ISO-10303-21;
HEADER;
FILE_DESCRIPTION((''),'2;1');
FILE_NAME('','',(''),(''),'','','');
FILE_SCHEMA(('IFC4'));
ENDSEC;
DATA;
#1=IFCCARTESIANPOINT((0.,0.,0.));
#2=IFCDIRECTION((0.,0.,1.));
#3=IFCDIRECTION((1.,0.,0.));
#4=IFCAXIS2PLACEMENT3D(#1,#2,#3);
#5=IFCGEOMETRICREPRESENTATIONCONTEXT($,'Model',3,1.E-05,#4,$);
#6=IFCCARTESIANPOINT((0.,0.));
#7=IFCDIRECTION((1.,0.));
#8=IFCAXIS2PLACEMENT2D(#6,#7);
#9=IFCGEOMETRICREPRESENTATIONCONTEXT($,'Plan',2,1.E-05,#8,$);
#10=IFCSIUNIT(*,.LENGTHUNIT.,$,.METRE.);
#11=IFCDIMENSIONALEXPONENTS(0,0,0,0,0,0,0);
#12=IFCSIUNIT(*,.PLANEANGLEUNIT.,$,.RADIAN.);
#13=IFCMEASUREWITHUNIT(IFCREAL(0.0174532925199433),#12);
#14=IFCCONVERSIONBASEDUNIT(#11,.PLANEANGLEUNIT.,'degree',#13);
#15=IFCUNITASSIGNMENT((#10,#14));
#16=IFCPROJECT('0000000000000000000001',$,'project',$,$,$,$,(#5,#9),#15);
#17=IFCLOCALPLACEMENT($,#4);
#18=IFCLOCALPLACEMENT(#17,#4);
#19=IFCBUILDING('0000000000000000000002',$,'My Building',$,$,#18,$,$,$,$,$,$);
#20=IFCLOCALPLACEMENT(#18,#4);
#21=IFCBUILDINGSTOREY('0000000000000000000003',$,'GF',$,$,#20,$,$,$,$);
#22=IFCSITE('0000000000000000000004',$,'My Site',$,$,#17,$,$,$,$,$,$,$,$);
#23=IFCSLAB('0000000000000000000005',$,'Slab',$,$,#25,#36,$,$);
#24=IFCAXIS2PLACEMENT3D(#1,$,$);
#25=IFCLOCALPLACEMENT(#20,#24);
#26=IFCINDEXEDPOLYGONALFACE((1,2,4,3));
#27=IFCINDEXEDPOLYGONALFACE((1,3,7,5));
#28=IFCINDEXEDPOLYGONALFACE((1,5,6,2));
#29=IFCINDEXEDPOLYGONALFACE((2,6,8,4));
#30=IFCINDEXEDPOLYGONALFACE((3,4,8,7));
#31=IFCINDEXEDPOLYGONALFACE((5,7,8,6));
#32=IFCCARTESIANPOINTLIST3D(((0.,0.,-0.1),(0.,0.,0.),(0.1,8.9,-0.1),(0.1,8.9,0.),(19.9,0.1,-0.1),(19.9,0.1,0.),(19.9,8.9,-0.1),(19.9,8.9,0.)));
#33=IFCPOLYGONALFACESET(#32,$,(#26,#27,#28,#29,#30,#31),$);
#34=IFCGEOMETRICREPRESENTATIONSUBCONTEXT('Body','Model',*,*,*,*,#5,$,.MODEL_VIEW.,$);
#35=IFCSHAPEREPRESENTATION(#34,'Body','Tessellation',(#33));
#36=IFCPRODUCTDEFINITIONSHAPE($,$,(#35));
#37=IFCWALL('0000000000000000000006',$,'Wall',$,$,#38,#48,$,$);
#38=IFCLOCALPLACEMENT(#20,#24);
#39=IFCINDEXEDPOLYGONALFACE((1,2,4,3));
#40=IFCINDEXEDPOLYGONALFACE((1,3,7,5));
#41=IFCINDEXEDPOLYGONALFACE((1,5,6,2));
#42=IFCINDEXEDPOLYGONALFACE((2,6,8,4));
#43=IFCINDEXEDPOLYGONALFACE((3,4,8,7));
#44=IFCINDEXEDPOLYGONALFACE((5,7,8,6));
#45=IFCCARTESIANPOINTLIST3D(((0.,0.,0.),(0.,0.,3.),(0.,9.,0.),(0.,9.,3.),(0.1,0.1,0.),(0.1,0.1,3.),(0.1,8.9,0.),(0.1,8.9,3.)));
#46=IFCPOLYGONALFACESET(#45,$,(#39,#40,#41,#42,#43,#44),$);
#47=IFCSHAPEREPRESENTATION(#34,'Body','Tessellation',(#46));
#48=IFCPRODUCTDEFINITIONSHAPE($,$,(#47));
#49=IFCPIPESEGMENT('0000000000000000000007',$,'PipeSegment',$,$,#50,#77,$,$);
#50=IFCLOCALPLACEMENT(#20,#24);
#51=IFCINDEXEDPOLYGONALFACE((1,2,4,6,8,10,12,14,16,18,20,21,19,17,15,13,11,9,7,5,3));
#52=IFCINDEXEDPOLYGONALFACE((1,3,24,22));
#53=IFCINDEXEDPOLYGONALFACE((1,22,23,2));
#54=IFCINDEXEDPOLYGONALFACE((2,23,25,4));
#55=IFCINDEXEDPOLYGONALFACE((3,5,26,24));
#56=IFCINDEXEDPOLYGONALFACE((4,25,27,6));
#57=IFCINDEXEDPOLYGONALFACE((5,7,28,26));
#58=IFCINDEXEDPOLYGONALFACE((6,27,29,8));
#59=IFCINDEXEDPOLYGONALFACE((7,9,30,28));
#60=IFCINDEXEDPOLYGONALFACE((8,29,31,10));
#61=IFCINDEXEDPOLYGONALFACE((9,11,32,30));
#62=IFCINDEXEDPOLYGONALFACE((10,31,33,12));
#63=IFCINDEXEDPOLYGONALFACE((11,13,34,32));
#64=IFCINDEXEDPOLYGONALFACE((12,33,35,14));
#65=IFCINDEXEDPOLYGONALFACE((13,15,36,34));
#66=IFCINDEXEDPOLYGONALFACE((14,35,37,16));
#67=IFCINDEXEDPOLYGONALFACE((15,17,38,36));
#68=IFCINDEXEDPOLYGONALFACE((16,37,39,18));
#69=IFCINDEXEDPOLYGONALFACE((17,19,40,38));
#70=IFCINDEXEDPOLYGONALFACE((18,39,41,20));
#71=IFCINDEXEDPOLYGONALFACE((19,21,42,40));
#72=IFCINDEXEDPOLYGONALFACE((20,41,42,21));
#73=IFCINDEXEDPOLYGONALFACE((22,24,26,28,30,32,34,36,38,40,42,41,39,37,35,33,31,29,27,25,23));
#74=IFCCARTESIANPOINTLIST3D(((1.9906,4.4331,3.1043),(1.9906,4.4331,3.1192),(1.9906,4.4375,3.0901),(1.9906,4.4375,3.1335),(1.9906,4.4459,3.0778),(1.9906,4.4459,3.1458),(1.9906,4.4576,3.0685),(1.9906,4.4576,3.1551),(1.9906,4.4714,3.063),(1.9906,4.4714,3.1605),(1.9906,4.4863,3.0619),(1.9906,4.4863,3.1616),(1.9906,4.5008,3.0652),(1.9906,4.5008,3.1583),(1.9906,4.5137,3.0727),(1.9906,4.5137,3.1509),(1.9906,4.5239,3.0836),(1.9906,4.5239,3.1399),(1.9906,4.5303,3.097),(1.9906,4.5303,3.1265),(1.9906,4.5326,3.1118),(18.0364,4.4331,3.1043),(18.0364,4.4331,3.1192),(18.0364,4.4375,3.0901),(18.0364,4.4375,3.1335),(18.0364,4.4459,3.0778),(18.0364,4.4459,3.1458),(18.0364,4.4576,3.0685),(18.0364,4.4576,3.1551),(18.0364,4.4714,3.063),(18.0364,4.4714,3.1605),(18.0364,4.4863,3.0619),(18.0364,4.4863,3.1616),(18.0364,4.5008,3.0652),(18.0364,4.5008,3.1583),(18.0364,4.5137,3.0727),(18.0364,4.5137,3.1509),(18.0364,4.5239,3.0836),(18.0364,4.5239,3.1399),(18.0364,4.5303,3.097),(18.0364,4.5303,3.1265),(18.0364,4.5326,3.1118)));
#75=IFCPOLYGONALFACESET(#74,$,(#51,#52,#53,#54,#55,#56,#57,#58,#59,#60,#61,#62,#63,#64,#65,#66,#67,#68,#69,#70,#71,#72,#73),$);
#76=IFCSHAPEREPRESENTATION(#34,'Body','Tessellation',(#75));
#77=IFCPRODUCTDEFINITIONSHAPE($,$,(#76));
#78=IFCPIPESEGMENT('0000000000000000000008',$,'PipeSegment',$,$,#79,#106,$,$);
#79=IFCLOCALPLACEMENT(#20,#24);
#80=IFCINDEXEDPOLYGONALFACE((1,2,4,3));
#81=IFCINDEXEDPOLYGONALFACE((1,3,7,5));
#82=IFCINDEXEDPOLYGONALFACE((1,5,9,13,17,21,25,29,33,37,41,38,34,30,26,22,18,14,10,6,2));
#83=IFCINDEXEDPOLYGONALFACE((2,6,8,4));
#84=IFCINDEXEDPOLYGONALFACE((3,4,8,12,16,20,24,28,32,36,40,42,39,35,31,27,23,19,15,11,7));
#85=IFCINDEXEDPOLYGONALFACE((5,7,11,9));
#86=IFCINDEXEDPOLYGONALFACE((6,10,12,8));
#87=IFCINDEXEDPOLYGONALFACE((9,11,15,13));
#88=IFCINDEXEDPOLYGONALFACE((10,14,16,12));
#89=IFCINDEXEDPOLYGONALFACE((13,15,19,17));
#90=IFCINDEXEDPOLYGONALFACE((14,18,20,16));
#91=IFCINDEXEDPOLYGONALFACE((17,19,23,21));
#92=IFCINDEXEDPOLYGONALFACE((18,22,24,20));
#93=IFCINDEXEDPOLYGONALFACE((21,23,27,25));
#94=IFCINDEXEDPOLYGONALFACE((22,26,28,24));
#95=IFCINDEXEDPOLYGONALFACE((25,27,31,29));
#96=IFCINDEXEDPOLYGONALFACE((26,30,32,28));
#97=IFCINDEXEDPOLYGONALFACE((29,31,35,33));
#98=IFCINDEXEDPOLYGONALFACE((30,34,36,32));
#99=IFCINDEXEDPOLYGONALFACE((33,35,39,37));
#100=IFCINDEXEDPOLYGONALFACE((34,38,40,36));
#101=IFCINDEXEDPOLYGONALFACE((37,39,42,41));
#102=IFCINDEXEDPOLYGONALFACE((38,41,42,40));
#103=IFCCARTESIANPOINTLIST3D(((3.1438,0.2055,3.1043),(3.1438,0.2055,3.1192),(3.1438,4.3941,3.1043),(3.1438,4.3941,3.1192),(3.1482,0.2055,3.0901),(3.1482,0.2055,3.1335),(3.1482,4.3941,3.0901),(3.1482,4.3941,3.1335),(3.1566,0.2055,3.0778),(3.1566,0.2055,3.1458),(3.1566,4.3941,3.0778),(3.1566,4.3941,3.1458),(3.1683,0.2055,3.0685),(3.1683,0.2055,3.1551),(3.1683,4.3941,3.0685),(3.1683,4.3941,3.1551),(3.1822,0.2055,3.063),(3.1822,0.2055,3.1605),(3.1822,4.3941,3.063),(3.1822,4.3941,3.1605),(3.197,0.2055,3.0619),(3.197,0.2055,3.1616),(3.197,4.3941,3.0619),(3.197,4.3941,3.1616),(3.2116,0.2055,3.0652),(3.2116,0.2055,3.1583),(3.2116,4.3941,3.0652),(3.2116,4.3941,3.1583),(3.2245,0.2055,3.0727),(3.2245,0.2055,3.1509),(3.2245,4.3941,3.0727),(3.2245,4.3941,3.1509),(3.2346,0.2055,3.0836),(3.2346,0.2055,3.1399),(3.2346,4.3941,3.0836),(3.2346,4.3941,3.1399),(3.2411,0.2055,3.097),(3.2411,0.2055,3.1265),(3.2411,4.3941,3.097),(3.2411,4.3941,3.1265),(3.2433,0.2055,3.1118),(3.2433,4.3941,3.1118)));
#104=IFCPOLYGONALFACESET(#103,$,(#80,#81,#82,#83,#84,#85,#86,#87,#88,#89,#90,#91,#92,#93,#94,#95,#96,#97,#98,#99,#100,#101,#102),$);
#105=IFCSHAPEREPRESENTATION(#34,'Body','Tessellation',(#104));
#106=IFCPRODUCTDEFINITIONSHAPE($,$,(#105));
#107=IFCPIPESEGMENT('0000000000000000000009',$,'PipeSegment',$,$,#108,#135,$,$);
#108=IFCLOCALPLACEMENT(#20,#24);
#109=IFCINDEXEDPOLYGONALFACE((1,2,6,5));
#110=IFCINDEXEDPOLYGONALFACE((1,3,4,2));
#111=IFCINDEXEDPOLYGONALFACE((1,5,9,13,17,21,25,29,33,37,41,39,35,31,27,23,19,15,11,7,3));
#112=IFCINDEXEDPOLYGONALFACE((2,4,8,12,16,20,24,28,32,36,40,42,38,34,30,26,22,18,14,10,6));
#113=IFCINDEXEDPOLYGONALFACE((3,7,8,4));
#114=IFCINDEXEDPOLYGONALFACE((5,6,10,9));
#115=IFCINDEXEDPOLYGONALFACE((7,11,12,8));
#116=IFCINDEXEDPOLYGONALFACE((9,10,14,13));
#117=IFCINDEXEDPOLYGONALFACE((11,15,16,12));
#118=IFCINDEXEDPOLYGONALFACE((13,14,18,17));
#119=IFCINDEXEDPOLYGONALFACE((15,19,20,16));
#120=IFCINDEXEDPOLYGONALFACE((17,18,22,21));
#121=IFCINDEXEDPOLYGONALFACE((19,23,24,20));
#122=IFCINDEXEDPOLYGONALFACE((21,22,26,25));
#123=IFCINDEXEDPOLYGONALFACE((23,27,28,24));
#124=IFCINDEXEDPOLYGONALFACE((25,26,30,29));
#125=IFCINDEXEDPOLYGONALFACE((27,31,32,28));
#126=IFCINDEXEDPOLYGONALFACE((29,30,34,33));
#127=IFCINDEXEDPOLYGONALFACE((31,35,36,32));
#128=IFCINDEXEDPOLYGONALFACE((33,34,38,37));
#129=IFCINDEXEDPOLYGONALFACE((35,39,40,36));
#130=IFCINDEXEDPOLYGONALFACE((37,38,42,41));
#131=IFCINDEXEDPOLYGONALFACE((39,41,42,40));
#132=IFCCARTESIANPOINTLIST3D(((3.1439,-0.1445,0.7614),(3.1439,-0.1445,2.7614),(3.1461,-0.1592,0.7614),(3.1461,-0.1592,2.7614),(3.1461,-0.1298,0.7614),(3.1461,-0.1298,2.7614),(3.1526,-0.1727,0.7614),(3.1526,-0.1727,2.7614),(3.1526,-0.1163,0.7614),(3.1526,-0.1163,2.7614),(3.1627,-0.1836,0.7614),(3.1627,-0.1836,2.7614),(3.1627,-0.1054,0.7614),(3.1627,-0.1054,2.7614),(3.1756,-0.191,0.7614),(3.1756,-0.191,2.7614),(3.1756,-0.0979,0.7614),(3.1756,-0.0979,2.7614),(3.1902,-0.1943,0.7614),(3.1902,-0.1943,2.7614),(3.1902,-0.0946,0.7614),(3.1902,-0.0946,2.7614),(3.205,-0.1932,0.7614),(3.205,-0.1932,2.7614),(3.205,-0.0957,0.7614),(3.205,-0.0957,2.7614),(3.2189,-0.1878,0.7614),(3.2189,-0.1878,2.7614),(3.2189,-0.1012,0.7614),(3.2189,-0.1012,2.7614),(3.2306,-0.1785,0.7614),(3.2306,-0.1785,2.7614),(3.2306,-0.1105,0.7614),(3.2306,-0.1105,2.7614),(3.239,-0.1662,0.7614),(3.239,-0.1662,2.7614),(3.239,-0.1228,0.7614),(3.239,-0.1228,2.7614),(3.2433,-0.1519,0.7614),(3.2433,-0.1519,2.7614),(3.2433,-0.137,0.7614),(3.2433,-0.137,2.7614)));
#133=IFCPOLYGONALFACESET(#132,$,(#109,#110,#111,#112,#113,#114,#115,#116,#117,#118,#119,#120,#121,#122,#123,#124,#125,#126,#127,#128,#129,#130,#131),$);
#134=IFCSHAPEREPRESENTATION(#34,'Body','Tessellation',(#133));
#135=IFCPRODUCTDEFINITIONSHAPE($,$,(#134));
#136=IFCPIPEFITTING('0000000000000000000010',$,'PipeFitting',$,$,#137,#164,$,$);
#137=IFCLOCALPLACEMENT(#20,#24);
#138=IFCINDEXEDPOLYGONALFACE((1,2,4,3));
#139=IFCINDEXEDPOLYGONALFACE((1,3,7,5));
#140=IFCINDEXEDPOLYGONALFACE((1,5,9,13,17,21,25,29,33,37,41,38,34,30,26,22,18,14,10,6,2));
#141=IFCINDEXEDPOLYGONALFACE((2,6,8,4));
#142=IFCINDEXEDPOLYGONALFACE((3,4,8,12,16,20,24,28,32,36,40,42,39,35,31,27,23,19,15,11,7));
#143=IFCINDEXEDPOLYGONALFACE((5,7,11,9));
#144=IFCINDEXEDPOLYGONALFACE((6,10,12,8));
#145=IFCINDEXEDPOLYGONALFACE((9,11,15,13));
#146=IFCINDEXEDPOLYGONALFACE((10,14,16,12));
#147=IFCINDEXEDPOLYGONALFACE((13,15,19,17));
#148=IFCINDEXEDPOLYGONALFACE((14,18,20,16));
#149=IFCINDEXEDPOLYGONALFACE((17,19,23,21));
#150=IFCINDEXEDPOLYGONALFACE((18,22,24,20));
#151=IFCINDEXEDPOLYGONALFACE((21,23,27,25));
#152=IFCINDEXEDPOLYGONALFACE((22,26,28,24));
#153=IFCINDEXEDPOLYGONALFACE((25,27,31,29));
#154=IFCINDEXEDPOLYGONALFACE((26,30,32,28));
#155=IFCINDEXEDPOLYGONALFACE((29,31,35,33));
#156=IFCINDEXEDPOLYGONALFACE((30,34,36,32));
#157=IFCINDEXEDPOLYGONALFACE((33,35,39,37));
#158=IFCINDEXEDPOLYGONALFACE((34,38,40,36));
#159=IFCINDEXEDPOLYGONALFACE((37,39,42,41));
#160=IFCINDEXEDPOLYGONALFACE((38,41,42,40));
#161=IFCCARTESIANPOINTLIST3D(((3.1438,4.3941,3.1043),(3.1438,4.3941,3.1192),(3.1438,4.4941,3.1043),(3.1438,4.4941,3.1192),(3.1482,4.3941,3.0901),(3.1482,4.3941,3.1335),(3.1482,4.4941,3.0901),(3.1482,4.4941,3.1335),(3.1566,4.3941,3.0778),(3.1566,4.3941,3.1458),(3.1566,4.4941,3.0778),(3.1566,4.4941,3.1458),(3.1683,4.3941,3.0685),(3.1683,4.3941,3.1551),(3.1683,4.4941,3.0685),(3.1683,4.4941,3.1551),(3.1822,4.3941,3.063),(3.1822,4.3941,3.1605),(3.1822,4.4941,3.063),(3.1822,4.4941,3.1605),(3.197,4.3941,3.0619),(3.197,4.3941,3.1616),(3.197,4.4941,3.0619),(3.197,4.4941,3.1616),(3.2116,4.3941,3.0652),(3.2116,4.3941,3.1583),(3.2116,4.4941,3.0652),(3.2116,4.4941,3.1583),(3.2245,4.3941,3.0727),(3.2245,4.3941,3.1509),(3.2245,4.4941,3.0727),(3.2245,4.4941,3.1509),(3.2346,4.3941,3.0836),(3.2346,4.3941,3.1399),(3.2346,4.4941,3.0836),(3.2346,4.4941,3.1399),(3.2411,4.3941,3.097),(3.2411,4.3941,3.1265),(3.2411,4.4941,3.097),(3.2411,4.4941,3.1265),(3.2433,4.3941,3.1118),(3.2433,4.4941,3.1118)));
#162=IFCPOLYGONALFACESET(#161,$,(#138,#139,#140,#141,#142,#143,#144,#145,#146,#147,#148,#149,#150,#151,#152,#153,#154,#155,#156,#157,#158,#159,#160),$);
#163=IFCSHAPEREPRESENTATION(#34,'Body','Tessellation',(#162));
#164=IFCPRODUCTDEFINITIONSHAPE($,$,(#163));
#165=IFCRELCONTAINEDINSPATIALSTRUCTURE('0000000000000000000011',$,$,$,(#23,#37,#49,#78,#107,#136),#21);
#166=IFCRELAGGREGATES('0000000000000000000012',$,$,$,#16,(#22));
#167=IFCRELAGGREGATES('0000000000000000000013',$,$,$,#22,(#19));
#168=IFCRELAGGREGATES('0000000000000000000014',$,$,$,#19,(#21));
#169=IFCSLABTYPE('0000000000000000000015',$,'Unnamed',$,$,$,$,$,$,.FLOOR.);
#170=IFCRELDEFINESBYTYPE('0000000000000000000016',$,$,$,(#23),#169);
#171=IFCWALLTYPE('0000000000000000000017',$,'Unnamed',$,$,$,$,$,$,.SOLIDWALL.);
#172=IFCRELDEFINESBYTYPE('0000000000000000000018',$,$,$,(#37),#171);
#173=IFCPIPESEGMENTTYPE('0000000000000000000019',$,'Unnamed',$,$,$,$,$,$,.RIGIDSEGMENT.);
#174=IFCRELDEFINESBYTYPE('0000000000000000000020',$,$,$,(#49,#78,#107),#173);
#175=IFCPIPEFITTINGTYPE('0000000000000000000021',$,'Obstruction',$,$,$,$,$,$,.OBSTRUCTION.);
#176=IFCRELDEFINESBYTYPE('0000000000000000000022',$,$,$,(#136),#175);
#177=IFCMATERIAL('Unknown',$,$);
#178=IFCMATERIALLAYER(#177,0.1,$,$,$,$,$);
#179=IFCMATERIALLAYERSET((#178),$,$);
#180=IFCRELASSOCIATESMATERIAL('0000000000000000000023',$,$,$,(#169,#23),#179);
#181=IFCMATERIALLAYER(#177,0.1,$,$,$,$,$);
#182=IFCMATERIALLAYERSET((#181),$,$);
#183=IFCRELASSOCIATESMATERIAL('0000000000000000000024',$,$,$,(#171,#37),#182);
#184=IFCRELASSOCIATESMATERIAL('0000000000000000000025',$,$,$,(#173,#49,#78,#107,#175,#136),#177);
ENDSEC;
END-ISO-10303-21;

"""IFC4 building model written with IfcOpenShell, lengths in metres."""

from ifc_helpers import new_model, entity, si_unit, converted_unit, frame, origin_with_axes, origin_2d_with_axis, place, context, subcontext, project, spatial, line, indexed_curve, circle, outline, extrude, material, layer, layer_set, layer_usage, material_profile, profile_set, profile_usage, type_object, element, save


model = new_model("IFC4")

# Units and contexts
model_context = context("Model", 3, precision=1e-05, world=origin_with_axes())
plan_context = context("Plan", 2, precision=1e-05, world=origin_2d_with_axis())
body_context_1 = subcontext(model_context, "Body", "Model", "MODEL_VIEW")
ifc_project = project(units=[si_unit("LENGTHUNIT", "METRE"), converted_unit("PLANEANGLEUNIT", "degree", entity("IfcReal", 0.0174532925199433), si_unit("PLANEANGLEUNIT", "RADIAN"), dimensions=[0, 0, 0, 0, 0, 0, 0])], contexts=[model_context, plan_context])

# Site, building, storey
site_placement = place(None, origin_with_axes())
site = spatial("IfcSite", under=ifc_project, at=site_placement, Name="My Site")
building_placement = place(site_placement, origin_with_axes())
building = spatial("IfcBuilding", under=site, at=building_placement, Name="My Building")
storey_placement = place(building_placement, origin_with_axes())
storey = spatial("IfcBuildingStorey", under=building, at=storey_placement, Name="GF")

# Slab
ifc_material = material(Name="Unknown")
ifc_layer_1 = layer(ifc_material, 0.1)
ifc_layer_set_1 = layer_set([ifc_layer_1])
ifc_layer_usage_1 = layer_usage(ifc_layer_set_1, "AXIS3", "POSITIVE", -0.1)
slab_type = type_object("IfcSlabType", Name="Unnamed", PredefinedType="FLOOR", material=ifc_layer_set_1)
slab_placement = place(storey_placement, frame((0.1, 8.9, 0.0), z_axis=(0.0, 0.0, 1.0), x_axis=(1.0, 0.0, 0.0)))
element("IfcSlab", 1, at=slab_placement, inside=storey, type_object=slab_type, material=ifc_layer_usage_1, Name="Slab", context=body_context_1, shape_type="SweptSolid", body=[
    extrude(outline(indexed_curve([(0.0, 0.0), (19.8, 0.0), (19.8, -8.8), (-0.1, -8.9), (0.0, 0.0)])), frame((0.0, 0.0, -0.1), z_axis=(0.0, 0.0, 1.0), x_axis=(1.0, 0.0, 0.0)), (0.0, 0.0, 1.0), 0.1),
])

# Shared definitions
ifc_layer_2 = layer(ifc_material, 0.1)
ifc_layer_set_2 = layer_set([ifc_layer_2])
wall_type = type_object("IfcWallType", Name="Unnamed", PredefinedType="SOLIDWALL", material=ifc_layer_set_2)

# Wall
ifc_layer_usage_2 = layer_usage(ifc_layer_set_2, "AXIS2", "POSITIVE", 0.0)
wall_1_placement = place(storey_placement, frame((0.0, 9.0, 0.0), z_axis=(0.0, 0.0, 1.0), x_axis=(0.0, -1.0, 0.0)))
element("IfcWall", 2, at=wall_1_placement, inside=storey, type_object=wall_type, material=ifc_layer_usage_2, Name="Wall", context=body_context_1, shape_type="SweptSolid", body=[
    extrude(outline(indexed_curve([(0.0, 0.0), (0.1, 0.1), (8.9, 0.1), (9.0, 0.0)], segments=[line(1, 2, 3, 4, 1)])), origin_with_axes(), (0.0, 0.0, 1.0), 3.0),
])

# Pipe segments
ifc_material_profile_1 = material_profile(ifc_material, circle(Radius=0.05))
ifc_profile_set_1 = profile_set([ifc_material_profile_1])
ifc_profile_usage_1 = profile_usage(ifc_profile_set_1, cardinal=5)
pipe_segment_type = type_object("IfcPipeSegmentType", Name="Unnamed", PredefinedType="RIGIDSEGMENT", material=ifc_profile_set_1)
pipe_segment_1_placement = place(storey_placement, frame((1.9906, 4.4826, 3.1118), z_axis=(1.0, 0.0, 0.0), x_axis=(0.0, 1.0, 0.0)))
element("IfcPipeSegment", 3, at=pipe_segment_1_placement, inside=storey, type_object=pipe_segment_type, material=ifc_profile_usage_1, Name="PipeSegment", context=body_context_1, shape_type="SweptSolid", body=[
    extrude(circle(Radius=0.05), origin_with_axes(), (0.0, 0.0, 1.0), 16.0459),
])
ifc_profile_usage_2 = profile_usage(ifc_profile_set_1, cardinal=5)
pipe_segment_2_placement = place(storey_placement, frame((3.1933, 4.3941, 3.1118), z_axis=(0.0, -1.0, 0.0), x_axis=(1.0, 0.0, 0.0)))
element("IfcPipeSegment", 4, at=pipe_segment_2_placement, inside=storey, type_object=pipe_segment_type, material=ifc_profile_usage_2, Name="PipeSegment", context=body_context_1, shape_type="SweptSolid", body=[
    extrude(circle(Radius=0.05), origin_with_axes(), (0.0, 0.0, 1.0), 4.1886),
])
ifc_profile_usage_3 = profile_usage(ifc_profile_set_1, cardinal=5)
pipe_segment_3_placement = place(storey_placement, frame((3.1939, -0.1445, 2.7614), z_axis=(0.0, 0.0, -1.0), x_axis=(-1.0, 0.0, 0.0)))
element("IfcPipeSegment", 5, at=pipe_segment_3_placement, inside=storey, type_object=pipe_segment_type, material=ifc_profile_usage_3, Name="PipeSegment", context=body_context_1, shape_type="SweptSolid", body=[
    extrude(circle(Radius=0.05), origin_with_axes(), (0.0, 0.0, 1.0), 2.0),
])

# Pipe fitting
ifc_material_profile_2 = material_profile(ifc_material, circle(Radius=0.05))
ifc_profile_set_2 = profile_set([ifc_material_profile_2])
ifc_profile_usage_4 = profile_usage(ifc_profile_set_2, cardinal=5)
pipe_fitting_type = type_object("IfcPipeFittingType", Name="Obstruction", PredefinedType="OBSTRUCTION", material=ifc_profile_set_2)
pipe_fitting_placement = place(storey_placement, frame((3.1933, 4.4941, 3.1118), z_axis=(0.0, -1.0, 0.0), x_axis=(1.0, 0.0, 0.0)))
element("IfcPipeFitting", 6, at=pipe_fitting_placement, inside=storey, type_object=pipe_fitting_type, material=ifc_profile_usage_4, Name="PipeFitting", context=body_context_1, shape_type="SweptSolid", body=[
    extrude(circle(Radius=0.05), origin_with_axes(), (0.0, 0.0, 1.0), 0.1),
])

save(model, "model.ifc")
